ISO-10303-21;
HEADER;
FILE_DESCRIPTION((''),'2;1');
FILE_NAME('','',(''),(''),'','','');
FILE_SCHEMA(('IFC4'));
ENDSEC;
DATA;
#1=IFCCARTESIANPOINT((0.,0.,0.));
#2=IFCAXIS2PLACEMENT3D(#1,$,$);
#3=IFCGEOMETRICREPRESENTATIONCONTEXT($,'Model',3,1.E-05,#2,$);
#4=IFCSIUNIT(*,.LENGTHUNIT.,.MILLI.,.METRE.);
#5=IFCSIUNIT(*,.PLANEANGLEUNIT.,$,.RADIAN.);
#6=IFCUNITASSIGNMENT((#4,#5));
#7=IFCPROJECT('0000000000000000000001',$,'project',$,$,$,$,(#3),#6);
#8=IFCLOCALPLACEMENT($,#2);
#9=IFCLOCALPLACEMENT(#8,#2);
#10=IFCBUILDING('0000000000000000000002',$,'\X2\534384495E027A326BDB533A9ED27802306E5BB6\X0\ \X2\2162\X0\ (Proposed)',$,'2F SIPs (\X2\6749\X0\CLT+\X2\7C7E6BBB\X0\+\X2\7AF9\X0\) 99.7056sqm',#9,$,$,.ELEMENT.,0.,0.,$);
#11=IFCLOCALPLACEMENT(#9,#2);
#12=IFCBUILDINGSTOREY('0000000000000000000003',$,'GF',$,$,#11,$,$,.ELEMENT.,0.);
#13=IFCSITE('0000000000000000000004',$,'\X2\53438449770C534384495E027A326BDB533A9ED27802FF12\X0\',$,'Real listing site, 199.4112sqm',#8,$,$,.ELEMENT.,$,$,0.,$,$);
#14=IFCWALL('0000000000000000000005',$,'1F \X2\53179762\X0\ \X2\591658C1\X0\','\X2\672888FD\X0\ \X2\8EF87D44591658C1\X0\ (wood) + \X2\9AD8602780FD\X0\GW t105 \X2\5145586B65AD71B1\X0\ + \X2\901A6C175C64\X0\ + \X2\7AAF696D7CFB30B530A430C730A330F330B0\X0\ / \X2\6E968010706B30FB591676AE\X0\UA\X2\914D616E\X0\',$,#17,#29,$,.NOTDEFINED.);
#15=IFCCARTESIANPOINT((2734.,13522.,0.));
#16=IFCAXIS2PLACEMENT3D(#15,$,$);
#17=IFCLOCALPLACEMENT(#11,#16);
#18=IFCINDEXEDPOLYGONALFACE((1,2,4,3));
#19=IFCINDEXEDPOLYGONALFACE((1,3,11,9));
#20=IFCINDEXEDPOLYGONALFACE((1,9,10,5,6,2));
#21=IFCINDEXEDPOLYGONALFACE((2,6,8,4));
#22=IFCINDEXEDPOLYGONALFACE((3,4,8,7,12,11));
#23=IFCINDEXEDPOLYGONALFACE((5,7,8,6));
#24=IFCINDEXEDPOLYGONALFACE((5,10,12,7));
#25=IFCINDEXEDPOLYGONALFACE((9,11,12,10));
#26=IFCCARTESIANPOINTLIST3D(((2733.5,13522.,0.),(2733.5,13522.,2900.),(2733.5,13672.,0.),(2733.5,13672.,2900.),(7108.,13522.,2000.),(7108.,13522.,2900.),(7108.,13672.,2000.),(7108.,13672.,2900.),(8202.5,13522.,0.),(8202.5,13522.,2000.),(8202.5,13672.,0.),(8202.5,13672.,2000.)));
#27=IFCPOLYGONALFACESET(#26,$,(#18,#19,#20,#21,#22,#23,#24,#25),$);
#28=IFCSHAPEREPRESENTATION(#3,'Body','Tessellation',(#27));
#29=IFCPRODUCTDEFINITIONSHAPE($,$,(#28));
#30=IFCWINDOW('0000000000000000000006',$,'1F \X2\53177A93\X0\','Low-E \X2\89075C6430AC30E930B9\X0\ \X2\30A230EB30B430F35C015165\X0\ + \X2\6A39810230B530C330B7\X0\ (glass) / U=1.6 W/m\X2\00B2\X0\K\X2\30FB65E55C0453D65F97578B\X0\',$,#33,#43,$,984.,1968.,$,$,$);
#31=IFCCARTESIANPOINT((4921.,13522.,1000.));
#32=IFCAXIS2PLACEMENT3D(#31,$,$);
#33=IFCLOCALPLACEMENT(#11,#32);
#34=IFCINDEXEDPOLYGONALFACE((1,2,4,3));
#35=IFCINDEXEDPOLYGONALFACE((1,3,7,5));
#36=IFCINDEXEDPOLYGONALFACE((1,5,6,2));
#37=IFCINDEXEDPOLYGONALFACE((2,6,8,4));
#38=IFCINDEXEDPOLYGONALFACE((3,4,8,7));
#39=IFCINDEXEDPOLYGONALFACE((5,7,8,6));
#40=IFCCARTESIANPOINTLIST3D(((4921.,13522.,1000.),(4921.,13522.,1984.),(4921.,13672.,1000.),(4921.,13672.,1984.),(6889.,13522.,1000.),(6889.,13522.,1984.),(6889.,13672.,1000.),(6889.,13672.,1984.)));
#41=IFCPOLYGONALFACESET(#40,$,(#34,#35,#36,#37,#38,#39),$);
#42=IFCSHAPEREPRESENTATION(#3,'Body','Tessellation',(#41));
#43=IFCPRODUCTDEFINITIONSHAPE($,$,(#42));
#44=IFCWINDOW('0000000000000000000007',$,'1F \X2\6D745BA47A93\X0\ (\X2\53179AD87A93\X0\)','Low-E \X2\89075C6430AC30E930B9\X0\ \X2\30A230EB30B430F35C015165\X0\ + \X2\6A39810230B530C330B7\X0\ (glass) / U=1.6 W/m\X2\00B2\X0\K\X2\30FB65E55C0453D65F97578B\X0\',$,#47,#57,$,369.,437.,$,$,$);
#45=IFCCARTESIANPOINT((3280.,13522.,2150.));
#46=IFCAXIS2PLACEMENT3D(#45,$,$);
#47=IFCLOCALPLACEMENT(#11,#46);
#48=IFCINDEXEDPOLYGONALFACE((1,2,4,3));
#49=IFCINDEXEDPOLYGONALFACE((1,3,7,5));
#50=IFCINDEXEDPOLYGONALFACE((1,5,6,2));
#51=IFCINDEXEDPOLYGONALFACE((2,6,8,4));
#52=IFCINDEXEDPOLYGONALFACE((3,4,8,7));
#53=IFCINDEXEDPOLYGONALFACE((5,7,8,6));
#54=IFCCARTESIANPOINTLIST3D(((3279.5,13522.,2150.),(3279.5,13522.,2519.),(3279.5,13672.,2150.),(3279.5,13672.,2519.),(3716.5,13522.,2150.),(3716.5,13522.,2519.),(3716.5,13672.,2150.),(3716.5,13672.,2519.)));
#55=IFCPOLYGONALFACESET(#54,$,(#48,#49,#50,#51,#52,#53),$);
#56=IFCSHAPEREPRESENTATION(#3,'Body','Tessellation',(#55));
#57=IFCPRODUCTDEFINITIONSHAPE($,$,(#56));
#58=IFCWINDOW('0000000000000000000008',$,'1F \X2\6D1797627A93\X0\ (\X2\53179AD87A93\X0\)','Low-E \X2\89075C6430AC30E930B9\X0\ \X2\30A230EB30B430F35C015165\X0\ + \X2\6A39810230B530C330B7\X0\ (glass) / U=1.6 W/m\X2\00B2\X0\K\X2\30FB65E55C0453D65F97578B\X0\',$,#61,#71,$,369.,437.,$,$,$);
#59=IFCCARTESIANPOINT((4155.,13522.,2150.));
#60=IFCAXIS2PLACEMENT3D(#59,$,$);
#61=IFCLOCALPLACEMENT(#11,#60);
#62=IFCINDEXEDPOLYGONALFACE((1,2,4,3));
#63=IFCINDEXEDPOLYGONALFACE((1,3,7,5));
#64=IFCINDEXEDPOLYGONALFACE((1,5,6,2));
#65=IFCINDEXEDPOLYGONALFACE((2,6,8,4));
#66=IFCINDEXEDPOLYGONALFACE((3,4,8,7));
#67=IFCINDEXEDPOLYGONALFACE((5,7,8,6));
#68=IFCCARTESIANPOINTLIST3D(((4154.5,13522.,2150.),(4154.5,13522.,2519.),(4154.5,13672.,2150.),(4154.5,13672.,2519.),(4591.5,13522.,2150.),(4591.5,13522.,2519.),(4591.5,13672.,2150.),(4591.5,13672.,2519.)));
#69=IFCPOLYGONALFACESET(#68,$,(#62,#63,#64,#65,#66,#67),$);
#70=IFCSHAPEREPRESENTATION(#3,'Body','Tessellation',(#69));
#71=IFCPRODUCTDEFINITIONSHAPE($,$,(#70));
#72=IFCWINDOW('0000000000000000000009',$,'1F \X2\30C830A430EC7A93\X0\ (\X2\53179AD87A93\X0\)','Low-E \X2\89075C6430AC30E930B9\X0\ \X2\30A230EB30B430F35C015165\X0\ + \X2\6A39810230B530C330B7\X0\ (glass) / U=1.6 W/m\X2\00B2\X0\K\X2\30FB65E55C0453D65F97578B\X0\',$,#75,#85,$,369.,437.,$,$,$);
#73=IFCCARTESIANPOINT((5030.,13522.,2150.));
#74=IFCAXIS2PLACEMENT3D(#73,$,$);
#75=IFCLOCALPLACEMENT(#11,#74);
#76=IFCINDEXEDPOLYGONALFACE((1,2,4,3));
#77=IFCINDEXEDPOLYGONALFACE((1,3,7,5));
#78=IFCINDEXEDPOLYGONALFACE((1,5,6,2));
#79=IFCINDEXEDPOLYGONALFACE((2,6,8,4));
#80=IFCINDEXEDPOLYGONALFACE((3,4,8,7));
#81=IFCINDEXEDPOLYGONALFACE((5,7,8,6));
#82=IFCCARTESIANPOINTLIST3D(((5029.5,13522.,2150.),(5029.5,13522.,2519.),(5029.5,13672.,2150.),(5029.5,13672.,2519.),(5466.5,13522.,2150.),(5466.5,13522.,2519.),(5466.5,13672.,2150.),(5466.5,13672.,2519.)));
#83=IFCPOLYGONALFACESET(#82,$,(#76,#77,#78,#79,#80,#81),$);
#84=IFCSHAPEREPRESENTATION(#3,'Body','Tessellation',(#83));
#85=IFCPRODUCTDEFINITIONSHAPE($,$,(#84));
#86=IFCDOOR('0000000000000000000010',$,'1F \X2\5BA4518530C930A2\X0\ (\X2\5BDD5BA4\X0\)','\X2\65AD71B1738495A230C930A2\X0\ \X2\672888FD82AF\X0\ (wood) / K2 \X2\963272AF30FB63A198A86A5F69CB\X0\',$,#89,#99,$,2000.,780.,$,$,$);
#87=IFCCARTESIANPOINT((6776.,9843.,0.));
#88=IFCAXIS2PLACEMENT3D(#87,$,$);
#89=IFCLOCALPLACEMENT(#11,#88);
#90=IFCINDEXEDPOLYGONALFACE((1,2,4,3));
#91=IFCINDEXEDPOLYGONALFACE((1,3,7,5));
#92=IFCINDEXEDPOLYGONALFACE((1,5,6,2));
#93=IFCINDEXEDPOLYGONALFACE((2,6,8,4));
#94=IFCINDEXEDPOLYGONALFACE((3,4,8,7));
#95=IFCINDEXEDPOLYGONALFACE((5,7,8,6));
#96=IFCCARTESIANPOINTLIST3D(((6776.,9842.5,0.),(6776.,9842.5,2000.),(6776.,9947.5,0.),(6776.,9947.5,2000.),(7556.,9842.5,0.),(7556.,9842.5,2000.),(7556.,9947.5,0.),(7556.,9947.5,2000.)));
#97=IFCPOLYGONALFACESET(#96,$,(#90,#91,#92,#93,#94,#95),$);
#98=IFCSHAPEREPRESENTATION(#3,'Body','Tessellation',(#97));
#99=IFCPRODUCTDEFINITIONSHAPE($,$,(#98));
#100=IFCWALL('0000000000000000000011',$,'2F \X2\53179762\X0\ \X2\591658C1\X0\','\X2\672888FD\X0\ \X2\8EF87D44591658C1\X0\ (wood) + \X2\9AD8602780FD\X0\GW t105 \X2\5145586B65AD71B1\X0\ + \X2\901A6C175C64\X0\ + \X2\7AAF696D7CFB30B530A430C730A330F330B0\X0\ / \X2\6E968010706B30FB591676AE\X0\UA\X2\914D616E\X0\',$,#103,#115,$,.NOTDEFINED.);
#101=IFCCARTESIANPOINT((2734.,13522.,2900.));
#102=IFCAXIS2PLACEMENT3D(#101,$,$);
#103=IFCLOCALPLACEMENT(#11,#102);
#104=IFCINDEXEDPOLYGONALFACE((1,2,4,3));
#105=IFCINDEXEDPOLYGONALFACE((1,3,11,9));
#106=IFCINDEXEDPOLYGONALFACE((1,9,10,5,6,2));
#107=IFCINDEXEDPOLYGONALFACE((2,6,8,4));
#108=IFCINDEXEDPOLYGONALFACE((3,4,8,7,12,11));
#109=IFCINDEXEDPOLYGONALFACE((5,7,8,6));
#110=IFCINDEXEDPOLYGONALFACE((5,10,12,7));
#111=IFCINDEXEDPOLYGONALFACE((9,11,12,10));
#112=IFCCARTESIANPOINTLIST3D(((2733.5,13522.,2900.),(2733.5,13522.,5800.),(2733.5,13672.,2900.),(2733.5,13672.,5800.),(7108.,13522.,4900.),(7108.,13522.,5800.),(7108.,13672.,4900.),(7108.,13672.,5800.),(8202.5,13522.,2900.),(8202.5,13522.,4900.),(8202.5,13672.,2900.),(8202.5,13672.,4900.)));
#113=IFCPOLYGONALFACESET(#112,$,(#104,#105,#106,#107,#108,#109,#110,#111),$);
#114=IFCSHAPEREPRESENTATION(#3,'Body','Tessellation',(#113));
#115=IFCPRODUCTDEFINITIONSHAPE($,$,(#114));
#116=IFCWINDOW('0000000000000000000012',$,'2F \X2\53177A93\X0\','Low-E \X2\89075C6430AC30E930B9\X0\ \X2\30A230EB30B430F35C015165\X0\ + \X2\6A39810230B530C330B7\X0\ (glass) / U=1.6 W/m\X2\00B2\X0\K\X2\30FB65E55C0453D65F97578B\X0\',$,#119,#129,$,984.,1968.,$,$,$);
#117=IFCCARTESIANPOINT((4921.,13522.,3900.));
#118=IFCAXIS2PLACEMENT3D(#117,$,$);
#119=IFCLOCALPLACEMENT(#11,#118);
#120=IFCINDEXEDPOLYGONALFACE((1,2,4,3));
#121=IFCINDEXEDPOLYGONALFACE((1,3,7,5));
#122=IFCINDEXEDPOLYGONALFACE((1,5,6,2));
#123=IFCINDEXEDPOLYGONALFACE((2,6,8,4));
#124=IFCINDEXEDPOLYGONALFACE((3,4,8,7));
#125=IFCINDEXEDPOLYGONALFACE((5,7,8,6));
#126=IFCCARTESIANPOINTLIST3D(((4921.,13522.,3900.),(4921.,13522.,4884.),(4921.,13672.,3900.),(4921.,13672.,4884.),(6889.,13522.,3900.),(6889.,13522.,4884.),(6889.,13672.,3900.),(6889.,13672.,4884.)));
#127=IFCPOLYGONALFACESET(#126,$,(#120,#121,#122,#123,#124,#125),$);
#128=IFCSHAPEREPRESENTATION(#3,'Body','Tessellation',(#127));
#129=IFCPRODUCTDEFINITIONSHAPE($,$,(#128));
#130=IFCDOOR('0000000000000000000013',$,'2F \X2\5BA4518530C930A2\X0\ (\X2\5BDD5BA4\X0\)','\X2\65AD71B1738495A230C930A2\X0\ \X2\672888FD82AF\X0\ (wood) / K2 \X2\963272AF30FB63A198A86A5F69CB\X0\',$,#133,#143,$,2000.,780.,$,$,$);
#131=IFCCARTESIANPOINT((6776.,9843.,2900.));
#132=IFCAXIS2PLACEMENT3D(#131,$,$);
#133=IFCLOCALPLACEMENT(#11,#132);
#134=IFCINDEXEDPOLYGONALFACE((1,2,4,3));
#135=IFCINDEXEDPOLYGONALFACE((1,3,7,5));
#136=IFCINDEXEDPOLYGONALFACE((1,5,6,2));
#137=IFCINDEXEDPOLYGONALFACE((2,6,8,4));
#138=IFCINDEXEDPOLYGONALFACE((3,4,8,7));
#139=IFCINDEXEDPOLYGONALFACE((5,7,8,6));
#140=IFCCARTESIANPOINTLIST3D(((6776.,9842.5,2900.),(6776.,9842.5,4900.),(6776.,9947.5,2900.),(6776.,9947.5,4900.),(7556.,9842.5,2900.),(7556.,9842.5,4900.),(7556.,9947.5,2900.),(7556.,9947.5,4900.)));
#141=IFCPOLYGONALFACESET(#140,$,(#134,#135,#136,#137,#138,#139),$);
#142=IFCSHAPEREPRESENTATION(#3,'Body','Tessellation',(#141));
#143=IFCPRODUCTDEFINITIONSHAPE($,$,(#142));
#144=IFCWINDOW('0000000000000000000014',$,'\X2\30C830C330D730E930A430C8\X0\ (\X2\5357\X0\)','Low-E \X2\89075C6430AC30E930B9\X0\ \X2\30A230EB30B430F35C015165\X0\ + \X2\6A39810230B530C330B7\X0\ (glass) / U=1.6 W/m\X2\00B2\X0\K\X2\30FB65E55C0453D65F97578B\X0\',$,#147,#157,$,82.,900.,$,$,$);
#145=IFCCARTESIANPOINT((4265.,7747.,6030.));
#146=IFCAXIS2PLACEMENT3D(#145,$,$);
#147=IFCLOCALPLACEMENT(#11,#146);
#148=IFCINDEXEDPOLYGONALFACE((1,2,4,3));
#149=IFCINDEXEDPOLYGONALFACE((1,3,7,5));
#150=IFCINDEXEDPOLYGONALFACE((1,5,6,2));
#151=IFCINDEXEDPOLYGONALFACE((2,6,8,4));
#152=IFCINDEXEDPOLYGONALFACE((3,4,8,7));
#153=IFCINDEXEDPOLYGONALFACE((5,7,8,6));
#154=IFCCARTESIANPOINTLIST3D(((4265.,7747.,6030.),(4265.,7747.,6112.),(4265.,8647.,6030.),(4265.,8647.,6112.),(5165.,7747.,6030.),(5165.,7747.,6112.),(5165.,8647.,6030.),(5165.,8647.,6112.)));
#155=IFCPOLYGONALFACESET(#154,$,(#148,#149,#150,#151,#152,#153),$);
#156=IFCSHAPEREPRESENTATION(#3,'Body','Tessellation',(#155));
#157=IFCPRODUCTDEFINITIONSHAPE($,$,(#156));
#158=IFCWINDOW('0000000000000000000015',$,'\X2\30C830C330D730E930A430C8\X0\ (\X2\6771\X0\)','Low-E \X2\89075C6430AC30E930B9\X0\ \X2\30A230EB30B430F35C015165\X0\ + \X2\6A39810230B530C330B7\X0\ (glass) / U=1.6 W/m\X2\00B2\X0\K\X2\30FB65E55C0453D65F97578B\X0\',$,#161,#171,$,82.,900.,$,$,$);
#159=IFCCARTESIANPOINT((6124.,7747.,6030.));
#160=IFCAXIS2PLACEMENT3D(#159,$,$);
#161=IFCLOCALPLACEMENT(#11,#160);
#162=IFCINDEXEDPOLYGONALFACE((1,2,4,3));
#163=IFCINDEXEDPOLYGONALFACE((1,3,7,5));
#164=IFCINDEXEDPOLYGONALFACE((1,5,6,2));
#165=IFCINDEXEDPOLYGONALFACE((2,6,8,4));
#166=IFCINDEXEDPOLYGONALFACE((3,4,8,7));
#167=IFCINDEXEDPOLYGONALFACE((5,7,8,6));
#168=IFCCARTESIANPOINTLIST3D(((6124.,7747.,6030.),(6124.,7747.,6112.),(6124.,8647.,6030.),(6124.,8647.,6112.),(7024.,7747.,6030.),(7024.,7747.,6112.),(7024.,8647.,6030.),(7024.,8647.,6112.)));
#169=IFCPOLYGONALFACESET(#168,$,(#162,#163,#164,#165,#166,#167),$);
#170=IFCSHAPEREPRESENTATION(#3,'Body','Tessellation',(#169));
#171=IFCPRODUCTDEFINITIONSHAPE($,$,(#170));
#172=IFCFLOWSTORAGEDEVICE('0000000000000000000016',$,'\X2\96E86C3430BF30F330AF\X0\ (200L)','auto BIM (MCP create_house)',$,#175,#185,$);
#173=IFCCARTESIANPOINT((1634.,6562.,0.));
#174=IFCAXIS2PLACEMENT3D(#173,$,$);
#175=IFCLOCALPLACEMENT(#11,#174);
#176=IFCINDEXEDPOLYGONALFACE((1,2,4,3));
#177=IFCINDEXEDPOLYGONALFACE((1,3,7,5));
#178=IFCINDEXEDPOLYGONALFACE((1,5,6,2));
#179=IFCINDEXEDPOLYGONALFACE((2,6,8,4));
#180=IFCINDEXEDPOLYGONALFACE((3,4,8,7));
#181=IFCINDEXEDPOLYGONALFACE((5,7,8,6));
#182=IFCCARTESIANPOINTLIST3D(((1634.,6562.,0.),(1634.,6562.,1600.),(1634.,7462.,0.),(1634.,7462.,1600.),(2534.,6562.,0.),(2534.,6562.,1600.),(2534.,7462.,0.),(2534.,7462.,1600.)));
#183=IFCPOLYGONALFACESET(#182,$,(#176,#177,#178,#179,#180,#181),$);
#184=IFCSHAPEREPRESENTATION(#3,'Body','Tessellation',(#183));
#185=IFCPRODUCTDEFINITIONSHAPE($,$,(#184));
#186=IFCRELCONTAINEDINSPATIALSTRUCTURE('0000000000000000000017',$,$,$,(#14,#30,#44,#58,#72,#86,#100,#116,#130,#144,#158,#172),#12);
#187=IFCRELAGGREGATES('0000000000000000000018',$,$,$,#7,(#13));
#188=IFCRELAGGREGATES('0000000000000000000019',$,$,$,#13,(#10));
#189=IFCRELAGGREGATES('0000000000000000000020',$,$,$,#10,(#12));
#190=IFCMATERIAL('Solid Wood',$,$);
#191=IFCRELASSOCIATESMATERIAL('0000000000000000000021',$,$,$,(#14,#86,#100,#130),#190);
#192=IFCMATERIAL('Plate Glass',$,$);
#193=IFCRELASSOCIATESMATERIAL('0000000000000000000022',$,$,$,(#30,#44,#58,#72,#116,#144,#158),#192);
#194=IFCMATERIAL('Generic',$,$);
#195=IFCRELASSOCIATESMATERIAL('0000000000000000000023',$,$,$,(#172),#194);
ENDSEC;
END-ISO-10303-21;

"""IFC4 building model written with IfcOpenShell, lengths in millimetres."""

from ifc_helpers import new_model, si_unit, frame, frame_2d, origin, place, context, project, spatial, rectangle, extrude, material, element, fill, save


model = new_model("IFC4")

# Units and contexts
model_context = context("Model", 3, precision=1e-05, world=origin())
ifc_project = project(units=[si_unit("LENGTHUNIT", "METRE", prefix="MILLI"), si_unit("PLANEANGLEUNIT", "RADIAN")], contexts=[model_context])

# Site, building, storey
site_placement = place(None, origin())
site = spatial("IfcSite", under=ifc_project, at=site_placement, Name="千葉県千葉市稲毛区黒砂２", ObjectType="Real listing site, 199.4112sqm", CompositionType="ELEMENT", RefElevation=0.0)
building_placement = place(site_placement, origin())
building = spatial("IfcBuilding", under=site, at=building_placement, Name="千葉市稲毛区黒砂の家 Ⅲ (Proposed)", ObjectType="2F SIPs (杉CLT+籾殻+竹) 99.7056sqm", CompositionType="ELEMENT", ElevationOfRefHeight=0.0, ElevationOfTerrain=0.0)
storey_placement = place(building_placement, origin())
storey = spatial("IfcBuildingStorey", under=building, at=storey_placement, Name="GF", CompositionType="ELEMENT", Elevation=0.0)

# Wall, openings, windows
ifc_material_1 = material(Name="Solid Wood")
wall_1_placement = place(storey_placement, frame((2734.0, 13522.0, 0.0)))
wall_1 = element("IfcWall", 1, at=wall_1_placement, inside=storey, material=ifc_material_1, Name="1F 北面 外壁", Description="木製 軸組外壁 (wood) + 高性能GW t105 充填断熱 + 通気層 + 窯業系サイディング / 準耐火・外皮UA配慮", PredefinedType="NOTDEFINED", context=model_context, shape_type="SweptSolid", body=[
    extrude(rectangle(XDim=5469.0, YDim=150.0, at=frame_2d((2734.0, 75.0))), frame((2734.0, 13522.0, 0.0)), (0.0, 0.0, 1.0), 2900.0),
])
opening_1_placement = place(storey_placement, frame((4921.0, 13522.0, 1000.0)))
opening_1 = element("IfcOpeningElement", 2, at=opening_1_placement, cuts=wall_1, PredefinedType="NOTDEFINED", context=model_context, shape_type="SweptSolid", body=[
    extrude(rectangle(XDim=1968.0, YDim=150.0, at=frame_2d((984.0, 75.0))), frame((4921.0, 13522.0, 1000.0)), (0.0, 0.0, 1.0), 984.0),
])
opening_2_placement = place(storey_placement, frame((3280.0, 13522.0, 2150.0)))
opening_2 = element("IfcOpeningElement", 3, at=opening_2_placement, cuts=wall_1, PredefinedType="NOTDEFINED", context=model_context, shape_type="SweptSolid", body=[
    extrude(rectangle(XDim=437.0, YDim=150.0, at=frame_2d((218.0, 75.0))), frame((3280.0, 13522.0, 2150.0)), (0.0, 0.0, 1.0), 369.0),
])
opening_3_placement = place(storey_placement, frame((4155.0, 13522.0, 2150.0)))
opening_3 = element("IfcOpeningElement", 4, at=opening_3_placement, cuts=wall_1, PredefinedType="NOTDEFINED", context=model_context, shape_type="SweptSolid", body=[
    extrude(rectangle(XDim=437.0, YDim=150.0, at=frame_2d((218.0, 75.0))), frame((4155.0, 13522.0, 2150.0)), (0.0, 0.0, 1.0), 369.0),
])
opening_4_placement = place(storey_placement, frame((5030.0, 13522.0, 2150.0)))
opening_4 = element("IfcOpeningElement", 5, at=opening_4_placement, cuts=wall_1, PredefinedType="NOTDEFINED", context=model_context, shape_type="SweptSolid", body=[
    extrude(rectangle(XDim=437.0, YDim=150.0, at=frame_2d((218.0, 75.0))), frame((5030.0, 13522.0, 2150.0)), (0.0, 0.0, 1.0), 369.0),
])
ifc_material_2 = material(Name="Plate Glass")
window_1_placement = place(storey_placement, frame((4921.0, 13522.0, 1000.0)))
window_1 = element("IfcWindow", 6, at=window_1_placement, inside=storey, material=ifc_material_2, Name="1F 北窓", Description="Low-E 複層ガラス アルゴン封入 + 樹脂サッシ (glass) / U=1.6 W/m²K・日射取得型", OverallHeight=984.0, OverallWidth=1968.0, context=model_context, shape_type="SweptSolid", body=[
    extrude(rectangle(XDim=1968.0, YDim=150.0, at=frame_2d((984.0, 75.0))), frame((4921.0, 13522.0, 1000.0)), (0.0, 0.0, 1.0), 984.0),
])
fill(opening_1, window_1)
window_2_placement = place(storey_placement, frame((3280.0, 13522.0, 2150.0)))
window_2 = element("IfcWindow", 7, at=window_2_placement, inside=storey, material=ifc_material_2, Name="1F 浴室窓 (北高窓)", Description="Low-E 複層ガラス アルゴン封入 + 樹脂サッシ (glass) / U=1.6 W/m²K・日射取得型", OverallHeight=369.0, OverallWidth=437.0, context=model_context, shape_type="SweptSolid", body=[
    extrude(rectangle(XDim=437.0, YDim=150.0, at=frame_2d((218.0, 75.0))), frame((3280.0, 13522.0, 2150.0)), (0.0, 0.0, 1.0), 369.0),
])
fill(opening_2, window_2)
window_3_placement = place(storey_placement, frame((4155.0, 13522.0, 2150.0)))
window_3 = element("IfcWindow", 8, at=window_3_placement, inside=storey, material=ifc_material_2, Name="1F 洗面窓 (北高窓)", Description="Low-E 複層ガラス アルゴン封入 + 樹脂サッシ (glass) / U=1.6 W/m²K・日射取得型", OverallHeight=369.0, OverallWidth=437.0, context=model_context, shape_type="SweptSolid", body=[
    extrude(rectangle(XDim=437.0, YDim=150.0, at=frame_2d((218.0, 75.0))), frame((4155.0, 13522.0, 2150.0)), (0.0, 0.0, 1.0), 369.0),
])
fill(opening_3, window_3)
window_4_placement = place(storey_placement, frame((5030.0, 13522.0, 2150.0)))
window_4 = element("IfcWindow", 9, at=window_4_placement, inside=storey, material=ifc_material_2, Name="1F トイレ窓 (北高窓)", Description="Low-E 複層ガラス アルゴン封入 + 樹脂サッシ (glass) / U=1.6 W/m²K・日射取得型", OverallHeight=369.0, OverallWidth=437.0, context=model_context, shape_type="SweptSolid", body=[
    extrude(rectangle(XDim=437.0, YDim=150.0, at=frame_2d((218.0, 75.0))), frame((5030.0, 13522.0, 2150.0)), (0.0, 0.0, 1.0), 369.0),
])
fill(opening_4, window_4)

# Door
door_1_placement = place(storey_placement, frame((6776.0, 9843.0, 0.0)))
element("IfcDoor", 10, at=door_1_placement, inside=storey, material=ifc_material_1, Name="1F 室内ドア (寝室)", Description="断熱玄関ドア 木製芯 (wood) / K2 防犯・採風機構", OverallHeight=2000.0, OverallWidth=780.0, context=model_context, shape_type="SweptSolid", body=[
    extrude(rectangle(XDim=780.0, YDim=105.0, at=frame_2d((390.0, 52.0))), frame((6776.0, 9843.0, 0.0)), (0.0, 0.0, 1.0), 2000.0),
])

# Wall, opening, window
wall_2_placement = place(storey_placement, frame((2734.0, 13522.0, 2900.0)))
wall_2 = element("IfcWall", 11, at=wall_2_placement, inside=storey, material=ifc_material_1, Name="2F 北面 外壁", Description="木製 軸組外壁 (wood) + 高性能GW t105 充填断熱 + 通気層 + 窯業系サイディング / 準耐火・外皮UA配慮", PredefinedType="NOTDEFINED", context=model_context, shape_type="SweptSolid", body=[
    extrude(rectangle(XDim=5469.0, YDim=150.0, at=frame_2d((2734.0, 75.0))), frame((2734.0, 13522.0, 2900.0)), (0.0, 0.0, 1.0), 2900.0),
])
opening_5_placement = place(storey_placement, frame((4921.0, 13522.0, 3900.0)))
opening_5 = element("IfcOpeningElement", 12, at=opening_5_placement, cuts=wall_2, PredefinedType="NOTDEFINED", context=model_context, shape_type="SweptSolid", body=[
    extrude(rectangle(XDim=1968.0, YDim=150.0, at=frame_2d((984.0, 75.0))), frame((4921.0, 13522.0, 3900.0)), (0.0, 0.0, 1.0), 984.0),
])
window_5_placement = place(storey_placement, frame((4921.0, 13522.0, 3900.0)))
window_5 = element("IfcWindow", 13, at=window_5_placement, inside=storey, material=ifc_material_2, Name="2F 北窓", Description="Low-E 複層ガラス アルゴン封入 + 樹脂サッシ (glass) / U=1.6 W/m²K・日射取得型", OverallHeight=984.0, OverallWidth=1968.0, context=model_context, shape_type="SweptSolid", body=[
    extrude(rectangle(XDim=1968.0, YDim=150.0, at=frame_2d((984.0, 75.0))), frame((4921.0, 13522.0, 3900.0)), (0.0, 0.0, 1.0), 984.0),
])
fill(opening_5, window_5)

# Door
door_2_placement = place(storey_placement, frame((6776.0, 9843.0, 2900.0)))
element("IfcDoor", 14, at=door_2_placement, inside=storey, material=ifc_material_1, Name="2F 室内ドア (寝室)", Description="断熱玄関ドア 木製芯 (wood) / K2 防犯・採風機構", OverallHeight=2000.0, OverallWidth=780.0, context=model_context, shape_type="SweptSolid", body=[
    extrude(rectangle(XDim=780.0, YDim=105.0, at=frame_2d((390.0, 52.0))), frame((6776.0, 9843.0, 2900.0)), (0.0, 0.0, 1.0), 2000.0),
])

# Windows
window_6_placement = place(storey_placement, frame((4265.0, 7747.0, 6030.0)))
element("IfcWindow", 15, at=window_6_placement, inside=storey, material=ifc_material_2, Name="トップライト (南)", Description="Low-E 複層ガラス アルゴン封入 + 樹脂サッシ (glass) / U=1.6 W/m²K・日射取得型", OverallHeight=82.0, OverallWidth=900.0, context=model_context, shape_type="SweptSolid", body=[
    extrude(rectangle(XDim=900.0, YDim=900.0, at=frame_2d((450.0, 450.0))), frame((4265.0, 7747.0, 6030.0)), (0.0, 0.0, 1.0), 82.0),
])
window_7_placement = place(storey_placement, frame((6124.0, 7747.0, 6030.0)))
element("IfcWindow", 16, at=window_7_placement, inside=storey, material=ifc_material_2, Name="トップライト (東)", Description="Low-E 複層ガラス アルゴン封入 + 樹脂サッシ (glass) / U=1.6 W/m²K・日射取得型", OverallHeight=82.0, OverallWidth=900.0, context=model_context, shape_type="SweptSolid", body=[
    extrude(rectangle(XDim=900.0, YDim=900.0, at=frame_2d((450.0, 450.0))), frame((6124.0, 7747.0, 6030.0)), (0.0, 0.0, 1.0), 82.0),
])

# Flow storage device
ifc_material_3 = material(Name="Generic")
flow_storage_device_placement = place(storey_placement, frame((1634.0, 6562.0, 0.0)))
element("IfcFlowStorageDevice", 17, at=flow_storage_device_placement, inside=storey, material=ifc_material_3, Name="雨水タンク (200L)", Description="auto BIM (MCP create_house)", context=model_context, shape_type="SweptSolid", body=[
    extrude(rectangle(XDim=900.0, YDim=900.0, at=frame_2d((450.0, 450.0))), frame((1634.0, 6562.0, 0.0)), (0.0, 0.0, 1.0), 1600.0),
])

save(model, "model.ifc")
